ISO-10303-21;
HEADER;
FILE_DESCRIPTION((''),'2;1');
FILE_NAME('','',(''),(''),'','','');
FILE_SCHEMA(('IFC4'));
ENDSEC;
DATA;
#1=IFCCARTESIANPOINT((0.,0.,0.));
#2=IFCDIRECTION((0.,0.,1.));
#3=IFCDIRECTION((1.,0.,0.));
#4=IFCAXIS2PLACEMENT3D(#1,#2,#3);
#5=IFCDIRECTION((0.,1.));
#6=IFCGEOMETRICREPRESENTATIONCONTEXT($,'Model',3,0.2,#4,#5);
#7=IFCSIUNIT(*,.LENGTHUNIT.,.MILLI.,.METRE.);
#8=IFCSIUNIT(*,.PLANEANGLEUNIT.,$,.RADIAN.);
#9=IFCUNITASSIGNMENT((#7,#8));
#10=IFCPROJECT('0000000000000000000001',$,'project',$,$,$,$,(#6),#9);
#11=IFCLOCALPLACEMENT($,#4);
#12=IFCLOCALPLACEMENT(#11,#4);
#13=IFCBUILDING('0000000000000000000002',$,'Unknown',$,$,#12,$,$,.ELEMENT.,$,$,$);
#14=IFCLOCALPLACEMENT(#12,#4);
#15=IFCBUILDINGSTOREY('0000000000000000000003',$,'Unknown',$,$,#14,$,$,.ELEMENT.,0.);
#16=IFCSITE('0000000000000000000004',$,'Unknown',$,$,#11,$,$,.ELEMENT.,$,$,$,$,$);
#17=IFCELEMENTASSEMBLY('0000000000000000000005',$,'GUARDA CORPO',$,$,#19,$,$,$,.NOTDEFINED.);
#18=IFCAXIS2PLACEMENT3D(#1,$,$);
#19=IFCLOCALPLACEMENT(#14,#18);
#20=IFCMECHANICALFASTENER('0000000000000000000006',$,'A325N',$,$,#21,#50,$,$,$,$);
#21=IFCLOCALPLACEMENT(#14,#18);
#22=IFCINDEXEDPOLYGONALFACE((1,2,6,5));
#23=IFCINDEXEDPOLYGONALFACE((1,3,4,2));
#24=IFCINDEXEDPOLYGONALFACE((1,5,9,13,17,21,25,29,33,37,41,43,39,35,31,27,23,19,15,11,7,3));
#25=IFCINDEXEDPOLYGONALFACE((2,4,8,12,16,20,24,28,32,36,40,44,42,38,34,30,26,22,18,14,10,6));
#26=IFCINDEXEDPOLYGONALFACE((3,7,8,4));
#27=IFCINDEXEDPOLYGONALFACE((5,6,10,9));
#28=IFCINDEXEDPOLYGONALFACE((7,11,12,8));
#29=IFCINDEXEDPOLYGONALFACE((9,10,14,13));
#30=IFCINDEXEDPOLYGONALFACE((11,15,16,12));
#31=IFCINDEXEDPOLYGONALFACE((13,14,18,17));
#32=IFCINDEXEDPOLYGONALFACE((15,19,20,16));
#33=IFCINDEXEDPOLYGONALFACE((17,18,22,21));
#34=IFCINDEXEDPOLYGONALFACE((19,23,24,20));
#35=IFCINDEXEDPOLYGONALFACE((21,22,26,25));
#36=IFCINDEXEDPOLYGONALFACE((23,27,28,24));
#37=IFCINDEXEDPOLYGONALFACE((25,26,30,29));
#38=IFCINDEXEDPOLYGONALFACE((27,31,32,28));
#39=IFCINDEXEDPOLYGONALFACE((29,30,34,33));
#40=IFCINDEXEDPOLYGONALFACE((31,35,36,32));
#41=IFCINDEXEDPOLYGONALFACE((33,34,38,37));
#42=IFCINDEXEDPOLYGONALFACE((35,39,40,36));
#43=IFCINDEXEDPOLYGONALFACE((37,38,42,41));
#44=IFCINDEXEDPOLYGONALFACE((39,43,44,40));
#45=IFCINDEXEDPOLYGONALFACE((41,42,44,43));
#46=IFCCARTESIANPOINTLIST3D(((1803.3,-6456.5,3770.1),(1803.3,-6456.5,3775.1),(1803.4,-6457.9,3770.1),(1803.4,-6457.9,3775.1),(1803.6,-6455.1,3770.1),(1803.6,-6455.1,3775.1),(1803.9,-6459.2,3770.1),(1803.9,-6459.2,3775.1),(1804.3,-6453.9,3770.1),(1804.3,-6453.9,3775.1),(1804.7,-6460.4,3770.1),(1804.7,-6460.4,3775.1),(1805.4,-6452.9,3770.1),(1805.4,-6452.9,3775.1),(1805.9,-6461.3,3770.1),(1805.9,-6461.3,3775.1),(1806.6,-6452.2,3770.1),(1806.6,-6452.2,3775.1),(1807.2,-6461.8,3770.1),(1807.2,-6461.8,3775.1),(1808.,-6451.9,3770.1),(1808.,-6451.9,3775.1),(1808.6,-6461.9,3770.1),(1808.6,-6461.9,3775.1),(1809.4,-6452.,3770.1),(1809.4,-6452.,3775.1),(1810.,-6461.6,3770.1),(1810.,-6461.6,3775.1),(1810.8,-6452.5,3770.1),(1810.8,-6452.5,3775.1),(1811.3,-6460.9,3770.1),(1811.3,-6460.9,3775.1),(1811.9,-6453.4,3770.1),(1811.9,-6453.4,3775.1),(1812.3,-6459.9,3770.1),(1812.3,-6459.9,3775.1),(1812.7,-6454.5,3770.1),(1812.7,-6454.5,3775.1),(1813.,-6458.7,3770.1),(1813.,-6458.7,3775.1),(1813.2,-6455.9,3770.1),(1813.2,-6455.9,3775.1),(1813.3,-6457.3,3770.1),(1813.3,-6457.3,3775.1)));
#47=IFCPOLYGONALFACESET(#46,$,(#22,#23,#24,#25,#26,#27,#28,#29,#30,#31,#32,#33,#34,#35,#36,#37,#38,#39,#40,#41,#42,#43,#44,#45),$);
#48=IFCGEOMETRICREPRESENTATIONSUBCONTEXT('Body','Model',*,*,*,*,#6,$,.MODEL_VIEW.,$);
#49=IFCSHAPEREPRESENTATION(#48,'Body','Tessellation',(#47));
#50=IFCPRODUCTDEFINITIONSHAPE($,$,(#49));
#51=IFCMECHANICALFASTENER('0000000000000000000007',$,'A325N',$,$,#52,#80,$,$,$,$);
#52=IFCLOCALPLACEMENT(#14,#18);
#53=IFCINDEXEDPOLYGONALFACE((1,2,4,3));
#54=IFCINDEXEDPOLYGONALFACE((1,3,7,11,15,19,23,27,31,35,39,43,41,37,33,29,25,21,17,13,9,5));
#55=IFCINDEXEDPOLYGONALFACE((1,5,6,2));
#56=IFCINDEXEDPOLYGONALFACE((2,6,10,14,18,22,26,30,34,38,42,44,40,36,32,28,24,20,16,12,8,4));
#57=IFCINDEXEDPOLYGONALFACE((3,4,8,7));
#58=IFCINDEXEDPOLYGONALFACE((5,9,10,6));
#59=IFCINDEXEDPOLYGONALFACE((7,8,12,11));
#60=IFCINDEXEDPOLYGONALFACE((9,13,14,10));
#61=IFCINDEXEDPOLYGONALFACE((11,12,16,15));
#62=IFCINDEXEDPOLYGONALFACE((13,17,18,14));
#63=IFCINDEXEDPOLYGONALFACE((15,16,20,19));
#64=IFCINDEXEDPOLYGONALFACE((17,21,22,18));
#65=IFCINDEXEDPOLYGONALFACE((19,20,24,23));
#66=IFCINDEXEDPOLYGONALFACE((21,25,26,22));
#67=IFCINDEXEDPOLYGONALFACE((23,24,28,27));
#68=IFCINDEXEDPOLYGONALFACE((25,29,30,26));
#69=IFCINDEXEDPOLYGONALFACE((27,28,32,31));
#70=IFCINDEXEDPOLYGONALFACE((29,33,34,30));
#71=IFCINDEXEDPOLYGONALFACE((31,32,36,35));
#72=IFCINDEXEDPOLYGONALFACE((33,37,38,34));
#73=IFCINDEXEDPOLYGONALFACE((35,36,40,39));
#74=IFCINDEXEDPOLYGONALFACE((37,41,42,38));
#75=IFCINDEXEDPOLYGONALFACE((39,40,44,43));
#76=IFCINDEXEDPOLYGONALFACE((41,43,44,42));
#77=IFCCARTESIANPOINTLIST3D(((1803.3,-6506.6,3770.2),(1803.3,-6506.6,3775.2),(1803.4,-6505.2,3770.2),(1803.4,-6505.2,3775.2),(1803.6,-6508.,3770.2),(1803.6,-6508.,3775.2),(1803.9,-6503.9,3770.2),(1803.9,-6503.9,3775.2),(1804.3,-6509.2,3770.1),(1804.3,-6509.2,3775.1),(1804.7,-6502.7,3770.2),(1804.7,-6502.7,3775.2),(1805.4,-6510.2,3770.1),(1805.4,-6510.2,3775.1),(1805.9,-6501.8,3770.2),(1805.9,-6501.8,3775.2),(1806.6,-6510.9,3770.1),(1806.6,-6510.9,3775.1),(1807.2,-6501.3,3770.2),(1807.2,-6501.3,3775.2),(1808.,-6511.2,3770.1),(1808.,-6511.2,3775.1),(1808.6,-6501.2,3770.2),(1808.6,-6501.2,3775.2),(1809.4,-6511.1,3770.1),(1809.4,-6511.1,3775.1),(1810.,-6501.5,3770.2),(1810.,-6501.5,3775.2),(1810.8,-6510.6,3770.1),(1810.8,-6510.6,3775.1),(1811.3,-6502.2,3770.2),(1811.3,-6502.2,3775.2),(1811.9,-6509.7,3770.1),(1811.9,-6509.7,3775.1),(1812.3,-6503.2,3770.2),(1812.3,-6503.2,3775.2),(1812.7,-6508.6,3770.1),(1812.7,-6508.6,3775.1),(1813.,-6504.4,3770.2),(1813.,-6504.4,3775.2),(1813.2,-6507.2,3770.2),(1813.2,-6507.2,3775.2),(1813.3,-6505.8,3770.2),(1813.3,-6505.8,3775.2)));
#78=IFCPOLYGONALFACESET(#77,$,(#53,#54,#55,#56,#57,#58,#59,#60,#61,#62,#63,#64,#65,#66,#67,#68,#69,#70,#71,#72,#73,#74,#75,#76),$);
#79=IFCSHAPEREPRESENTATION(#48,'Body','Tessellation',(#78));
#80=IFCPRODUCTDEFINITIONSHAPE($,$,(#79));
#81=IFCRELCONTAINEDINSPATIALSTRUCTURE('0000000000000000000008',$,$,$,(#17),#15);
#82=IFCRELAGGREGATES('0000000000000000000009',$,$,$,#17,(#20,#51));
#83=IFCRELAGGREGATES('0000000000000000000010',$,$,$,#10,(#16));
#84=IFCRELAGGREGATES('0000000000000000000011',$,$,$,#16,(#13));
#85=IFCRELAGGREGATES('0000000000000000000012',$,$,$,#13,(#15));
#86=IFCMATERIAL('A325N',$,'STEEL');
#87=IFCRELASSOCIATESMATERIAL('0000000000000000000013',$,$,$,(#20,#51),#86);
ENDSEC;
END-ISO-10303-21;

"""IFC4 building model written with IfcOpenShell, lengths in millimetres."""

from ifc_helpers import new_model, si_unit, direction, frame, origin_with_axes, place, context, subcontext, project, spatial, arc, indexed_curve, outline, extrude, source, transform, mapped, material, element, aggregate, save


model = new_model("IFC4")

# Units and contexts
model_context = context("Model", 3, precision=0.2, world=origin_with_axes(), true_north=direction((0.0, 1.0)))
body_context = subcontext(model_context, "Body", "Model", "MODEL_VIEW")
ifc_project = project(units=[si_unit("LENGTHUNIT", "METRE", prefix="MILLI"), si_unit("PLANEANGLEUNIT", "RADIAN")], contexts=[model_context])

# Site, building, storey
site_placement = place(None, origin_with_axes())
site = spatial("IfcSite", under=ifc_project, at=site_placement, Name="Unknown", CompositionType="ELEMENT")
building_placement = place(site_placement, origin_with_axes())
building = spatial("IfcBuilding", under=site, at=building_placement, Name="Unknown", CompositionType="ELEMENT")
storey_placement = place(building_placement, origin_with_axes())
storey = spatial("IfcBuildingStorey", under=building, at=storey_placement, Name="Unknown", CompositionType="ELEMENT", Elevation=0.0)

# Element assembly
assembly_1_placement = place(storey_placement, frame((1808.2, -6481.4, 3775.1), z_axis=(0.000512, 1.0, -0.000003), x_axis=(0.000003, 0.000003, 1.0)))
assembly_1 = element("IfcElementAssembly", 1, at=assembly_1_placement, inside=storey, Name="GUARDA CORPO", PredefinedType="NOTDEFINED")

# Mechanical fasteners
ifc_material_1 = material(Name="A325N", Category="STEEL")
shared_shape_1 = source(origin_with_axes(), body_context, "Body", "SweptSolid", [
    extrude(outline(indexed_curve([(5.0, 0.0), (0.0, 5.0), (-5.0, 0.0), (0.0, -5.0)], segments=[arc(1, 2, 3), arc(3, 4, 1)])), frame((0.0, 0.0, 0.0), z_axis=(0.0, 0.0, -1.0), x_axis=(0.0, 1.0, 0.0)), (0.0, 0.0, 1.0), 5.0),
])
mechanical_fastener_1_placement = place(assembly_1_placement, frame((0.0, 0.1, 24.5), z_axis=(1.0, -0.000003, -0.000001), x_axis=(0.0, 0.471397, -0.881921)))
mechanical_fastener_1 = element("IfcMechanicalFastener", 2, at=mechanical_fastener_1_placement, material=ifc_material_1, Name="A325N", context=body_context, shape_type="MappedRepresentation", body=[
    mapped(shared_shape_1, transform((0.0, 0.0, 0.0))),
])
shared_shape_2 = source(origin_with_axes(), body_context, "Body", "SweptSolid", [
    extrude(outline(indexed_curve([(5.0, 0.0), (0.0, 5.0), (-5.0, 0.0), (0.0, -5.0)], segments=[arc(1, 2, 3), arc(3, 4, 1)])), frame((0.0, 0.0, 0.0), z_axis=(0.0, 0.0, -1.0), x_axis=(0.0, 1.0, 0.0)), (0.0, 0.0, 1.0), 5.0),
])
mechanical_fastener_2_placement = place(assembly_1_placement, frame((0.0, 0.1, -24.8), z_axis=(1.0, -0.000003, -0.000005), x_axis=(0.000005, 0.470493, 0.882404)))
mechanical_fastener_2 = element("IfcMechanicalFastener", 3, at=mechanical_fastener_2_placement, material=ifc_material_1, Name="A325N", context=body_context, shape_type="MappedRepresentation", body=[
    mapped(shared_shape_2, transform((0.0, 0.0, 0.0))),
])
aggregate(assembly_1, [mechanical_fastener_1, mechanical_fastener_2])

save(model, "model.ifc")
